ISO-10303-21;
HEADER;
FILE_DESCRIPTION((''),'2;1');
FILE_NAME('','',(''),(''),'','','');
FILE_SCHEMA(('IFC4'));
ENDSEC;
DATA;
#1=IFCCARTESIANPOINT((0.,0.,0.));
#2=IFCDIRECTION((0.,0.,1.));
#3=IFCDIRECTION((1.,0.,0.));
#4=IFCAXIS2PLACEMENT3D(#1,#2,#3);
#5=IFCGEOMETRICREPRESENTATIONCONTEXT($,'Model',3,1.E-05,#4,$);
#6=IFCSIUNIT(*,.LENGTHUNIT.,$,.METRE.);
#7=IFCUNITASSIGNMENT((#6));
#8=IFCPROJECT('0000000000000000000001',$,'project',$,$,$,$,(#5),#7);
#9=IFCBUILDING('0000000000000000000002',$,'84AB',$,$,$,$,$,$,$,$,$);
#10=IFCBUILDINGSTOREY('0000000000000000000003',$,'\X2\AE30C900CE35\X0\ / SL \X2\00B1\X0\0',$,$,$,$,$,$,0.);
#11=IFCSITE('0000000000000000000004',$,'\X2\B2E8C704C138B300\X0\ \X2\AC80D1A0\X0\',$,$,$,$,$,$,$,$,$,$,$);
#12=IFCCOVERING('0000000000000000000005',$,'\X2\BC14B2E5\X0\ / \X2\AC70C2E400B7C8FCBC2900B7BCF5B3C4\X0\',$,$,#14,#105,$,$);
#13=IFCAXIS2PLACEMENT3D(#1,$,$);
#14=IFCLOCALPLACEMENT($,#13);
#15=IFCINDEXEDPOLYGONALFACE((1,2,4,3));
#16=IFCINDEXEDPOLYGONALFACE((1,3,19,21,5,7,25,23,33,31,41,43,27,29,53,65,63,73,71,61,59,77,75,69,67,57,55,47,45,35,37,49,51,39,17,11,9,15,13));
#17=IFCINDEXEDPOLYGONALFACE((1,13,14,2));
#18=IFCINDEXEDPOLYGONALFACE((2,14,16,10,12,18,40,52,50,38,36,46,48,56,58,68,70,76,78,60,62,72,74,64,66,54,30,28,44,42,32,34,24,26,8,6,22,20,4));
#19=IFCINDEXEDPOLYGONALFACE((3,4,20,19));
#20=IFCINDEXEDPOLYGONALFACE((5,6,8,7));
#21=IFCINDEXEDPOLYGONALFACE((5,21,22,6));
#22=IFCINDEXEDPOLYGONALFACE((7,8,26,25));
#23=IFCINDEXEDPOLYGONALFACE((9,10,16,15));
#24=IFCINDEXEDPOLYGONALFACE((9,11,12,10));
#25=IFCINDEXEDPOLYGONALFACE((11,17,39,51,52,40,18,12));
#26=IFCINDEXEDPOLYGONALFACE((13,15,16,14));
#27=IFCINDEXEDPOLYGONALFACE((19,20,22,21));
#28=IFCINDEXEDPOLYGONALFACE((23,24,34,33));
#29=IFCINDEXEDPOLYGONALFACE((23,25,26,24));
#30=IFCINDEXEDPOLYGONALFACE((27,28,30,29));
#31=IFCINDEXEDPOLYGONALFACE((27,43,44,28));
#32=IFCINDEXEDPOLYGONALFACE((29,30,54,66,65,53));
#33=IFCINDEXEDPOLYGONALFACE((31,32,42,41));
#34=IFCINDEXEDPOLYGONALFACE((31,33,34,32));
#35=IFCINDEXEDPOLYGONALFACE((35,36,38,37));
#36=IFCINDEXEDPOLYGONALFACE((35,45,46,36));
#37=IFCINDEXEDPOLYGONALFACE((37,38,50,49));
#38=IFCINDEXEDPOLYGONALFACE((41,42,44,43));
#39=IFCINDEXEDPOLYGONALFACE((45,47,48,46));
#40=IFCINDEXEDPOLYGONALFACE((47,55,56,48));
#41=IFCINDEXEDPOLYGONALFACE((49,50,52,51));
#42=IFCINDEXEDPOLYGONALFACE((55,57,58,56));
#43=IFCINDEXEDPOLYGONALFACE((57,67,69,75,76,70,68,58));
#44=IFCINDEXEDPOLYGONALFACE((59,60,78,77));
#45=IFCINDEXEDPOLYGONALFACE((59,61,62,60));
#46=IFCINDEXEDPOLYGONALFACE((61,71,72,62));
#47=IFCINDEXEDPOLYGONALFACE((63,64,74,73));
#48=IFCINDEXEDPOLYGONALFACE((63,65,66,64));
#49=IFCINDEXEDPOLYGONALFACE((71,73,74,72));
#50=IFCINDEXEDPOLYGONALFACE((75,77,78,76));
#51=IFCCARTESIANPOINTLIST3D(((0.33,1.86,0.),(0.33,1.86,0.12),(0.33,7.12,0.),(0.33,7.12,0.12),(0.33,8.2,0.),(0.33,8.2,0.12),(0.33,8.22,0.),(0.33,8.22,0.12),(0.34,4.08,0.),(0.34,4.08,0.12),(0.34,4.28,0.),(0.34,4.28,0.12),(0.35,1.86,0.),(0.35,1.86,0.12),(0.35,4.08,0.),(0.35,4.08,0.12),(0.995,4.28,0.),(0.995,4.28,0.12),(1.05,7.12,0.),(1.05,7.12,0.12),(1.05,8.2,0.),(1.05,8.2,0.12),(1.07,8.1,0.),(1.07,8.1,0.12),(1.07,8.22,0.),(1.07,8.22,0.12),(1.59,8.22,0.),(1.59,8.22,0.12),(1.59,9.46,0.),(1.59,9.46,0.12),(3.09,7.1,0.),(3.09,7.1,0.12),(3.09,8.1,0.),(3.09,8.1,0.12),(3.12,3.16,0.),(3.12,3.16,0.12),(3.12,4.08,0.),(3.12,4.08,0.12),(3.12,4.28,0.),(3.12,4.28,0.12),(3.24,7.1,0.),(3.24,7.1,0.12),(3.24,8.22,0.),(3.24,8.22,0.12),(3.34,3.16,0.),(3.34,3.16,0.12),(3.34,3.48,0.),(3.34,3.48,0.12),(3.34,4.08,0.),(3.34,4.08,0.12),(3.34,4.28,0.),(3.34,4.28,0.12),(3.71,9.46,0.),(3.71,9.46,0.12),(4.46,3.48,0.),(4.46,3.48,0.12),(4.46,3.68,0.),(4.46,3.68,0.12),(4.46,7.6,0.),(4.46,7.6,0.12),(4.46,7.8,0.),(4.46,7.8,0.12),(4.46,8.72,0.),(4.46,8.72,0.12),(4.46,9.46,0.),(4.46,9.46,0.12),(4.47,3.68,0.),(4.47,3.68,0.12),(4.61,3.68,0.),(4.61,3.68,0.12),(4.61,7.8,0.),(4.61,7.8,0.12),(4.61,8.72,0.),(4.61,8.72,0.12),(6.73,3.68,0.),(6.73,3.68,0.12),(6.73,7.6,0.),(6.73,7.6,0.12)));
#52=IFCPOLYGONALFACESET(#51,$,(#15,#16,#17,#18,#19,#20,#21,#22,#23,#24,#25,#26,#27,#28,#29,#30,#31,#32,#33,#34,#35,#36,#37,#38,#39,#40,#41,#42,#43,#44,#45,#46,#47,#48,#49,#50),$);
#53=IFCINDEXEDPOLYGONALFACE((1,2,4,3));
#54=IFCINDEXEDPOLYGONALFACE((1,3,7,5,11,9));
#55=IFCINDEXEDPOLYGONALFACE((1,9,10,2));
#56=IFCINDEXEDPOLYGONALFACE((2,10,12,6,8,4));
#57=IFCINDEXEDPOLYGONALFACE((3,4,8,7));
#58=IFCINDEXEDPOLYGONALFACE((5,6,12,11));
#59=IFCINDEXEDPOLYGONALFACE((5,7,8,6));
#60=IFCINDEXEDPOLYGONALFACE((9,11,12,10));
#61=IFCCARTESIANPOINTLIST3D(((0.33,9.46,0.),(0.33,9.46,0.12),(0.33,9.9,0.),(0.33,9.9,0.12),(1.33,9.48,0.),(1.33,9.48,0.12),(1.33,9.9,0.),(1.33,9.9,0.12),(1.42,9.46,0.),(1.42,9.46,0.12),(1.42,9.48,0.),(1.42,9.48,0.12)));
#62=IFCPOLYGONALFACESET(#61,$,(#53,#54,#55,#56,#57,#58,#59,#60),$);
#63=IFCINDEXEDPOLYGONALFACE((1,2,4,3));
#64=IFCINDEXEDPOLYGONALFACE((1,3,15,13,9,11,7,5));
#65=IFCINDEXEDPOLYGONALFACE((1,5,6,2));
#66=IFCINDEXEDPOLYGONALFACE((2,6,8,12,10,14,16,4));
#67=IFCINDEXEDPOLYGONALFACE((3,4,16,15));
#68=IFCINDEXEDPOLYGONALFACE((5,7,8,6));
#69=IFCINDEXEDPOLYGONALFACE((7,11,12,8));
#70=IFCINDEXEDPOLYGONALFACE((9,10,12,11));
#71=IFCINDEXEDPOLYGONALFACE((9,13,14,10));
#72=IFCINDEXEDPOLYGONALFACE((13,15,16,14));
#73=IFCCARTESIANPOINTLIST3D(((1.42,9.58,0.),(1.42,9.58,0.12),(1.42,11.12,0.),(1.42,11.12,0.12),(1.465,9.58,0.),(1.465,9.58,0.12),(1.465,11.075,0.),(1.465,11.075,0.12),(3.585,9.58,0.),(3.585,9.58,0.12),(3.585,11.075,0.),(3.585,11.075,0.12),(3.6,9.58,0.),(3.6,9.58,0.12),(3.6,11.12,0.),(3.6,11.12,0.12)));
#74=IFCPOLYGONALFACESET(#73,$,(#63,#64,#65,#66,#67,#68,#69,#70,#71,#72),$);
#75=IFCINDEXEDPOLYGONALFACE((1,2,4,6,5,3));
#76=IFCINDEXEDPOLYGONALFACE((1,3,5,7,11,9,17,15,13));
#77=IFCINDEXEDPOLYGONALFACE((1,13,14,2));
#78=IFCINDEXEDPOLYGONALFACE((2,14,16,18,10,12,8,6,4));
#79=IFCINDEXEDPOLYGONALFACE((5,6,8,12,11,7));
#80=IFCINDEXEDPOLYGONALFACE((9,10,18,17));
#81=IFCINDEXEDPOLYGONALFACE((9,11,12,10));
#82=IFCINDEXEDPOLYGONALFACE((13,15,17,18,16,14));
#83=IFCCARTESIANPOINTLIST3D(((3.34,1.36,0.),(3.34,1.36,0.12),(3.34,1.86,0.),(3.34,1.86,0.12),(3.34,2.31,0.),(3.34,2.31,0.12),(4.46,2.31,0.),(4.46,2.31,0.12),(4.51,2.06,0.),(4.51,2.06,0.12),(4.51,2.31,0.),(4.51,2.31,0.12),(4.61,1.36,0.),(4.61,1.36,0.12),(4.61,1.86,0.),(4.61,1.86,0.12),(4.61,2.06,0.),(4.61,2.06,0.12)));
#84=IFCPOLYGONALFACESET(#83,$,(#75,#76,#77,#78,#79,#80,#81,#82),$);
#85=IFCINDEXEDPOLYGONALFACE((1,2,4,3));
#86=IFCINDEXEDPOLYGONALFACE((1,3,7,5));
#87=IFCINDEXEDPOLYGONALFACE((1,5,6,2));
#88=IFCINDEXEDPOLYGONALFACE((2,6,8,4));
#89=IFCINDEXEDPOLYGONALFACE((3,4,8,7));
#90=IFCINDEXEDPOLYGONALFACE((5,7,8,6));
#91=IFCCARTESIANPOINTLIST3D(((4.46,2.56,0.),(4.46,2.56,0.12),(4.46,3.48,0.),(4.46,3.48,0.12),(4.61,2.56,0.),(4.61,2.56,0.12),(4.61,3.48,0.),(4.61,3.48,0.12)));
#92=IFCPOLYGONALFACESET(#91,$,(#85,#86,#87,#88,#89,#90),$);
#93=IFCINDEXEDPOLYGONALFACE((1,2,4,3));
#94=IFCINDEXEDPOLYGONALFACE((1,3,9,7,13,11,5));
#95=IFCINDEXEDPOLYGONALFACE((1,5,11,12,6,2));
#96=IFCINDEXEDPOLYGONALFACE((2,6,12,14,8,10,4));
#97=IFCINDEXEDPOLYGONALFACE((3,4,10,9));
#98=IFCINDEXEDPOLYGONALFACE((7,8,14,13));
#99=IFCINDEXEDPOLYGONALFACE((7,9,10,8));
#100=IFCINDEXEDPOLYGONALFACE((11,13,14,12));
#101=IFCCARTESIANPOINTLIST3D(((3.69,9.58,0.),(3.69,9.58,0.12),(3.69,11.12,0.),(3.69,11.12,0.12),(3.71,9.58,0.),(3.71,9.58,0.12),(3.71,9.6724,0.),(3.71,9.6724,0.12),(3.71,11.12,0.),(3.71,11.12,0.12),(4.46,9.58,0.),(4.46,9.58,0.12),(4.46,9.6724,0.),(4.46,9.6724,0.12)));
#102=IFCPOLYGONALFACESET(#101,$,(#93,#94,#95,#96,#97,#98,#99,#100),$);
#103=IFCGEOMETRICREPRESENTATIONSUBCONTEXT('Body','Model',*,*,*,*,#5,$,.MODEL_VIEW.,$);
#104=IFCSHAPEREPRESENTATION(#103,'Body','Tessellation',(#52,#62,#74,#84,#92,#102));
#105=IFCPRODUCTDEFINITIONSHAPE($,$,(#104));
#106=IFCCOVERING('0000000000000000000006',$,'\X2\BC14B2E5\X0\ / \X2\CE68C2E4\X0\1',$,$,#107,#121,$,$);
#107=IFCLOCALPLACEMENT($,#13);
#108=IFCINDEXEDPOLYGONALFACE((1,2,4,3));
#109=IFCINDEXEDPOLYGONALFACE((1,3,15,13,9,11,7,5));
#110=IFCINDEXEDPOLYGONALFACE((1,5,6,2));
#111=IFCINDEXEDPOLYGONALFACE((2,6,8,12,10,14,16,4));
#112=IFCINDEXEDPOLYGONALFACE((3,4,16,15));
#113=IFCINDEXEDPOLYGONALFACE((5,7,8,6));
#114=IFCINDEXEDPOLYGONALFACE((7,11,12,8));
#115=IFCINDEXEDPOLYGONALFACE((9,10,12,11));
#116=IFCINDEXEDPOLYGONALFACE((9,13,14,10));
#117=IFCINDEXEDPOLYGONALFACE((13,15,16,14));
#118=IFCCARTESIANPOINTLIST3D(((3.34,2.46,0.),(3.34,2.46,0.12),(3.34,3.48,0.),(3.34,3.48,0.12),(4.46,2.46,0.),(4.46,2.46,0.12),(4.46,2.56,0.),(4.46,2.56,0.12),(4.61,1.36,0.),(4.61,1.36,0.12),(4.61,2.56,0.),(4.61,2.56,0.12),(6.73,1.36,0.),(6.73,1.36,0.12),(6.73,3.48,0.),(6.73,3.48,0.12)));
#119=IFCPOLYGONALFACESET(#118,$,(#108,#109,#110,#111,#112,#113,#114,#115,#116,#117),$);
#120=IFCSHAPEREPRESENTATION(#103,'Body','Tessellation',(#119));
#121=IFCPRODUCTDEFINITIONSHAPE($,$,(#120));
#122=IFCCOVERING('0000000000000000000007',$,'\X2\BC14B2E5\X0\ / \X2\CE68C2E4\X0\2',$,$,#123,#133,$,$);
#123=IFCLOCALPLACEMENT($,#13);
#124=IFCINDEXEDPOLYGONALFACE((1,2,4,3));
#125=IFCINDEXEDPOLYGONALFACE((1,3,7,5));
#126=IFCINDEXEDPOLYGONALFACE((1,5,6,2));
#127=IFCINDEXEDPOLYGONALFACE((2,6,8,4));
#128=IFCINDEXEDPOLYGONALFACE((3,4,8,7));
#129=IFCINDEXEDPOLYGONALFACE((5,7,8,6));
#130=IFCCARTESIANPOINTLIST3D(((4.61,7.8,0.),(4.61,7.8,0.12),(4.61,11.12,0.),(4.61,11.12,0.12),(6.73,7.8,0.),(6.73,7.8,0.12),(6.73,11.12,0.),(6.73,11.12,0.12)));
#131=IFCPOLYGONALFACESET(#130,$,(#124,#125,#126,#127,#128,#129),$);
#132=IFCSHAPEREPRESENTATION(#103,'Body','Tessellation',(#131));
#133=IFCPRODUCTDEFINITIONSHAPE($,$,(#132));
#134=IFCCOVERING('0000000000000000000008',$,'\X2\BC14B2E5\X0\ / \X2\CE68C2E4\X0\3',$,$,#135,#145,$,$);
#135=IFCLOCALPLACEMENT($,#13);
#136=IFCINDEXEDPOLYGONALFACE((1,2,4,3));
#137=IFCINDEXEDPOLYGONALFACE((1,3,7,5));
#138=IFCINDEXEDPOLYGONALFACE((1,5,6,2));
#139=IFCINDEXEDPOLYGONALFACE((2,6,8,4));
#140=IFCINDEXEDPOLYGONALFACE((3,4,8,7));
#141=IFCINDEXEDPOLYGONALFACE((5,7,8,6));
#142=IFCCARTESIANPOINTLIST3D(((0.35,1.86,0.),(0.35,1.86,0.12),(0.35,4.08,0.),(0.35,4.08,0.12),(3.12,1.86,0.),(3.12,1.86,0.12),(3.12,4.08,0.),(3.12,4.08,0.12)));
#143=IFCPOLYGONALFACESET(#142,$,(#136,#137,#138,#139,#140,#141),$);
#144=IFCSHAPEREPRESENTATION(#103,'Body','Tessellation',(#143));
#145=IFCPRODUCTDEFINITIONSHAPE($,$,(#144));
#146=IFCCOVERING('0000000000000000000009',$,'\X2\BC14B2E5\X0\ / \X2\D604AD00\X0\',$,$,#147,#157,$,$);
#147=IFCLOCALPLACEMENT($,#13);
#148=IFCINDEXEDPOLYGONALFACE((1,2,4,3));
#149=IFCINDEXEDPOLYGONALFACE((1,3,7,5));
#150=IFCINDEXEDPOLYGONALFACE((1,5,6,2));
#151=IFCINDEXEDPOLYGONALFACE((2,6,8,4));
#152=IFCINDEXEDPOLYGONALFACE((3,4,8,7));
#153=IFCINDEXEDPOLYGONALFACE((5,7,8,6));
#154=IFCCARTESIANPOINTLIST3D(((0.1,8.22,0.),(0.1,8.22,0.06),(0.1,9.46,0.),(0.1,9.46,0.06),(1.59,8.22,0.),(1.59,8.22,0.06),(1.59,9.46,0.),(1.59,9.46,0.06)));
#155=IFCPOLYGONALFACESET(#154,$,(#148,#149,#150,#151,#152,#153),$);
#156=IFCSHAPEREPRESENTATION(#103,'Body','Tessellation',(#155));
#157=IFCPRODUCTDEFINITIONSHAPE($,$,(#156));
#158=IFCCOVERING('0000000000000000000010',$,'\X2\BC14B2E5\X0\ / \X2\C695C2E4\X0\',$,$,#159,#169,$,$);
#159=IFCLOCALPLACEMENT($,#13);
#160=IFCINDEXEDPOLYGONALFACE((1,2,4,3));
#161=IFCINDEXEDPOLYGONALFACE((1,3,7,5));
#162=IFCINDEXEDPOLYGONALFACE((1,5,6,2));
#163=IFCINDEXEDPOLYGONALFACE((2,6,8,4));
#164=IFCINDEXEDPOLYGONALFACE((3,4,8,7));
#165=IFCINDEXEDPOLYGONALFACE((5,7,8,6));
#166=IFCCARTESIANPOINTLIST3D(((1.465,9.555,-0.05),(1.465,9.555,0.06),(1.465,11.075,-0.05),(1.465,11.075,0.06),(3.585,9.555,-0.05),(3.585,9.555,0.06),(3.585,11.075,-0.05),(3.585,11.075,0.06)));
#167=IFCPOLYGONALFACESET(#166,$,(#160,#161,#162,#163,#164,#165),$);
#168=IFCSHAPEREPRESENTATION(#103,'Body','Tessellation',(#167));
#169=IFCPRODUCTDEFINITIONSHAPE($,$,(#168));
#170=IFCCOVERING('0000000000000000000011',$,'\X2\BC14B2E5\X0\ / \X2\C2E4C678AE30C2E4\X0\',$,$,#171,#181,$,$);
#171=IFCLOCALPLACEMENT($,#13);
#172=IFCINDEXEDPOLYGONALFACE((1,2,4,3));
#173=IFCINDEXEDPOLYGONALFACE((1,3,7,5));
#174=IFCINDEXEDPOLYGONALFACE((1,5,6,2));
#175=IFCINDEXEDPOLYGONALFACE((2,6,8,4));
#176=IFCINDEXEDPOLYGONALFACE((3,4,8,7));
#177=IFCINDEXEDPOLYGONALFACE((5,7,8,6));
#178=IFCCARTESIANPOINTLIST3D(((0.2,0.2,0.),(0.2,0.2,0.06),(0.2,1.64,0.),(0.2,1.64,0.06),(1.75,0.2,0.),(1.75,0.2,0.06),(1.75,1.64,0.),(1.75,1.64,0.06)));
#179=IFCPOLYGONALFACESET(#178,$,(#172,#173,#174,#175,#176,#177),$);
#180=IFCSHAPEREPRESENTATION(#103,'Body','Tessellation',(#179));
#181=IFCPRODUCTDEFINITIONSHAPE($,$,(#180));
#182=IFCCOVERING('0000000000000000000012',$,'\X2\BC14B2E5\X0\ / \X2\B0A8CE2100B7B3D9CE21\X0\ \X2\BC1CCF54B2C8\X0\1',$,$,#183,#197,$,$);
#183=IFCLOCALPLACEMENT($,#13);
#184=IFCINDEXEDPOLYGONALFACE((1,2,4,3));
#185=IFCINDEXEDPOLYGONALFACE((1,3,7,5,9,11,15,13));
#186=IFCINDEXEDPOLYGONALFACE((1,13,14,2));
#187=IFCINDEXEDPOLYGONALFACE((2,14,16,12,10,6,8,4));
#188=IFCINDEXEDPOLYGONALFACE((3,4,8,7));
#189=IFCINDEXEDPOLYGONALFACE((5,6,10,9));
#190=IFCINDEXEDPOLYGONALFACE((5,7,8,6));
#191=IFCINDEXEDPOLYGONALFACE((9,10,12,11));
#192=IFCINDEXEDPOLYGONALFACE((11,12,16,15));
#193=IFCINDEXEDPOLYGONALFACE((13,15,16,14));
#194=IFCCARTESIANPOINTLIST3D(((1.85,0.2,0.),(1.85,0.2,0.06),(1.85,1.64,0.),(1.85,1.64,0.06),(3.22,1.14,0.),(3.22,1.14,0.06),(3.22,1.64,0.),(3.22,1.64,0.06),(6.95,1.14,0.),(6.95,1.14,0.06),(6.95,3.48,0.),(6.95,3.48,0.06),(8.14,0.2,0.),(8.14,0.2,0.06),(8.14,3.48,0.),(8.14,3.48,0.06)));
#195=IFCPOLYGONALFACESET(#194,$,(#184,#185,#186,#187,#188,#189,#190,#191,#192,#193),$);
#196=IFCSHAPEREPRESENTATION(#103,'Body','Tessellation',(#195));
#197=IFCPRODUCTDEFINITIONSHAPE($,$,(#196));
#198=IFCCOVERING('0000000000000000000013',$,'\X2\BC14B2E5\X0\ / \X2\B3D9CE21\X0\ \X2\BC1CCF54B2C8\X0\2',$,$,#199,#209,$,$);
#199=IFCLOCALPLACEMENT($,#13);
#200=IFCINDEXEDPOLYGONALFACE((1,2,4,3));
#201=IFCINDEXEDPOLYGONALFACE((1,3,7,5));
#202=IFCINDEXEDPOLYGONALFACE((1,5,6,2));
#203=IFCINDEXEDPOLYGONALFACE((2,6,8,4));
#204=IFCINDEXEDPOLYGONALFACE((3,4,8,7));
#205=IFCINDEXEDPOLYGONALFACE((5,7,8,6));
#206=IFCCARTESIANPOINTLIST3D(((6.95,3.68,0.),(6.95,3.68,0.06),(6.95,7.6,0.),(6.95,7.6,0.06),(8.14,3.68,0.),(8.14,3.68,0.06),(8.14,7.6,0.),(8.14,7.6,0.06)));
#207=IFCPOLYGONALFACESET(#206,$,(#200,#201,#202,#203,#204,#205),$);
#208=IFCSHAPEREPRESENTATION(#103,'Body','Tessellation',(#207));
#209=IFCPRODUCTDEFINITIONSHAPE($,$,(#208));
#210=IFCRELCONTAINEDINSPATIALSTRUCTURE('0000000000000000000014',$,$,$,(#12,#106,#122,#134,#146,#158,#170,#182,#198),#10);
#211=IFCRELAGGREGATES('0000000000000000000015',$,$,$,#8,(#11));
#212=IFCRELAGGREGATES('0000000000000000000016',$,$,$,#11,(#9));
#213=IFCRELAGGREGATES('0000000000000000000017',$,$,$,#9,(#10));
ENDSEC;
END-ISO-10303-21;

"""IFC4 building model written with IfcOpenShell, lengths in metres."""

from ifc_helpers import new_model, si_unit, frame, origin, origin_with_axes, place, context, subcontext, project, spatial, polyline, outline, extrude, element, save


model = new_model("IFC4")

# Units and contexts
model_context = context("Model", 3, precision=1e-05, world=origin_with_axes())
body_context = subcontext(model_context, "Body", "Model", "MODEL_VIEW")
ifc_project = project(units=[si_unit("LENGTHUNIT", "METRE")], contexts=[model_context])

# Site, building, storey
site = spatial("IfcSite", under=ifc_project, Name="단위세대 검토")
building = spatial("IfcBuilding", under=site, Name="84AB")
storey = spatial("IfcBuildingStorey", under=building, Name="기준층 / SL ±0", Elevation=0.0)

# Coverings
covering_1_placement = place(None, origin_with_axes())
element("IfcCovering", 1, at=covering_1_placement, inside=storey, Name="바닥 / 거실·주방·복도", context=body_context, shape_type="SweptSolid", body=[
    extrude(outline(polyline([(3.12, 4.08), (3.34, 4.08), (3.34, 4.28), (3.12, 4.28), (0.995, 4.28), (0.34, 4.28), (0.34, 4.08), (0.35, 4.08), (0.35, 1.86), (0.33, 1.86), (0.33, 7.12), (1.05, 7.12), (1.05, 8.2), (0.33, 8.2), (0.33, 8.22), (1.07, 8.22), (1.07, 8.1), (3.09, 8.1), (3.09, 7.1), (3.24, 7.1), (3.24, 8.22), (1.59, 8.22), (1.59, 9.46), (3.71, 9.46), (4.46, 9.46), (4.46, 8.72), (4.61, 8.72), (4.61, 7.8), (4.46, 7.8), (4.46, 7.6), (6.73, 7.6), (6.73, 3.68), (4.61, 3.68), (4.47, 3.68), (4.46, 3.68), (4.46, 3.48), (3.34, 3.48), (3.34, 3.16), (3.12, 3.16), (3.12, 4.08)])), origin(), (0.0, 0.0, 1.0), 0.12),
    extrude(outline(polyline([(1.42, 9.46), (0.33, 9.46), (0.33, 9.9), (1.33, 9.9), (1.33, 9.48), (1.42, 9.48), (1.42, 9.46)])), origin(), (0.0, 0.0, 1.0), 0.12),
    extrude(outline(polyline([(1.465, 11.075), (1.465, 9.58), (1.42, 9.58), (1.42, 11.12), (3.6, 11.12), (3.6, 9.58), (3.585, 9.58), (3.585, 11.075), (1.465, 11.075)])), origin(), (0.0, 0.0, 1.0), 0.12),
    extrude(outline(polyline([(3.34, 2.31), (4.46, 2.31), (4.51, 2.31), (4.51, 2.06), (4.61, 2.06), (4.61, 1.86), (4.61, 1.36), (3.34, 1.36), (3.34, 1.86), (3.34, 2.31)])), origin(), (0.0, 0.0, 1.0), 0.12),
    extrude(outline(polyline([(4.61, 3.48), (4.61, 2.56), (4.46, 2.56), (4.46, 3.48), (4.61, 3.48)])), origin(), (0.0, 0.0, 1.0), 0.12),
    extrude(outline(polyline([(3.71, 9.58), (3.69, 9.58), (3.69, 11.12), (3.71, 11.12), (3.71, 9.6724), (4.46, 9.6724), (4.46, 9.58), (3.71, 9.58)])), origin(), (0.0, 0.0, 1.0), 0.12),
])
covering_2_placement = place(None, origin_with_axes())
element("IfcCovering", 2, at=covering_2_placement, inside=storey, Name="바닥 / 침실1", context=body_context, shape_type="SweptSolid", body=[
    extrude(outline(polyline([(3.34, 2.46), (4.46, 2.46), (4.46, 2.56), (4.61, 2.56), (4.61, 1.36), (6.73, 1.36), (6.73, 3.48), (3.34, 3.48), (3.34, 2.46)])), origin(), (0.0, 0.0, 1.0), 0.12),
])
covering_3_placement = place(None, origin_with_axes())
element("IfcCovering", 3, at=covering_3_placement, inside=storey, Name="바닥 / 침실2", context=body_context, shape_type="SweptSolid", body=[
    extrude(outline(polyline([(6.73, 7.8), (6.73, 11.12), (4.61, 11.12), (4.61, 7.8), (6.73, 7.8)])), origin(), (0.0, 0.0, 1.0), 0.12),
])
covering_4_placement = place(None, origin_with_axes())
element("IfcCovering", 4, at=covering_4_placement, inside=storey, Name="바닥 / 침실3", context=body_context, shape_type="SweptSolid", body=[
    extrude(outline(polyline([(3.12, 1.86), (3.12, 4.08), (0.35, 4.08), (0.35, 1.86), (3.12, 1.86)])), origin(), (0.0, 0.0, 1.0), 0.12),
])
covering_5_placement = place(None, origin_with_axes())
element("IfcCovering", 5, at=covering_5_placement, inside=storey, Name="바닥 / 현관", context=body_context, shape_type="SweptSolid", body=[
    extrude(outline(polyline([(1.59, 8.22), (1.59, 9.46), (0.1, 9.46), (0.1, 8.22), (1.59, 8.22)])), origin(), (0.0, 0.0, 1.0), 0.06),
])
covering_6_placement = place(None, origin_with_axes())
element("IfcCovering", 6, at=covering_6_placement, inside=storey, Name="바닥 / 욕실", context=body_context, shape_type="SweptSolid", body=[
    extrude(outline(polyline([(3.585, 11.075), (1.465, 11.075), (1.465, 9.555), (3.585, 9.555), (3.585, 11.075)])), frame((0.0, 0.0, -0.05)), (0.0, 0.0, 1.0), 0.11),
])
covering_7_placement = place(None, origin_with_axes())
element("IfcCovering", 7, at=covering_7_placement, inside=storey, Name="바닥 / 실외기실", context=body_context, shape_type="SweptSolid", body=[
    extrude(outline(polyline([(1.75, 0.2), (1.75, 1.64), (0.2, 1.64), (0.2, 0.2), (1.75, 0.2)])), origin(), (0.0, 0.0, 1.0), 0.06),
])
covering_8_placement = place(None, origin_with_axes())
element("IfcCovering", 8, at=covering_8_placement, inside=storey, Name="바닥 / 남측·동측 발코니1", context=body_context, shape_type="SweptSolid", body=[
    extrude(outline(polyline([(1.85, 0.2), (8.14, 0.2), (8.14, 3.48), (6.95, 3.48), (6.95, 1.14), (3.22, 1.14), (3.22, 1.64), (1.85, 1.64), (1.85, 0.2)])), origin(), (0.0, 0.0, 1.0), 0.06),
])
covering_9_placement = place(None, origin_with_axes())
element("IfcCovering", 9, at=covering_9_placement, inside=storey, Name="바닥 / 동측 발코니2", context=body_context, shape_type="SweptSolid", body=[
    extrude(outline(polyline([(8.14, 3.68), (8.14, 7.6), (6.95, 7.6), (6.95, 3.68), (8.14, 3.68)])), origin(), (0.0, 0.0, 1.0), 0.06),
])

save(model, "model.ifc")
